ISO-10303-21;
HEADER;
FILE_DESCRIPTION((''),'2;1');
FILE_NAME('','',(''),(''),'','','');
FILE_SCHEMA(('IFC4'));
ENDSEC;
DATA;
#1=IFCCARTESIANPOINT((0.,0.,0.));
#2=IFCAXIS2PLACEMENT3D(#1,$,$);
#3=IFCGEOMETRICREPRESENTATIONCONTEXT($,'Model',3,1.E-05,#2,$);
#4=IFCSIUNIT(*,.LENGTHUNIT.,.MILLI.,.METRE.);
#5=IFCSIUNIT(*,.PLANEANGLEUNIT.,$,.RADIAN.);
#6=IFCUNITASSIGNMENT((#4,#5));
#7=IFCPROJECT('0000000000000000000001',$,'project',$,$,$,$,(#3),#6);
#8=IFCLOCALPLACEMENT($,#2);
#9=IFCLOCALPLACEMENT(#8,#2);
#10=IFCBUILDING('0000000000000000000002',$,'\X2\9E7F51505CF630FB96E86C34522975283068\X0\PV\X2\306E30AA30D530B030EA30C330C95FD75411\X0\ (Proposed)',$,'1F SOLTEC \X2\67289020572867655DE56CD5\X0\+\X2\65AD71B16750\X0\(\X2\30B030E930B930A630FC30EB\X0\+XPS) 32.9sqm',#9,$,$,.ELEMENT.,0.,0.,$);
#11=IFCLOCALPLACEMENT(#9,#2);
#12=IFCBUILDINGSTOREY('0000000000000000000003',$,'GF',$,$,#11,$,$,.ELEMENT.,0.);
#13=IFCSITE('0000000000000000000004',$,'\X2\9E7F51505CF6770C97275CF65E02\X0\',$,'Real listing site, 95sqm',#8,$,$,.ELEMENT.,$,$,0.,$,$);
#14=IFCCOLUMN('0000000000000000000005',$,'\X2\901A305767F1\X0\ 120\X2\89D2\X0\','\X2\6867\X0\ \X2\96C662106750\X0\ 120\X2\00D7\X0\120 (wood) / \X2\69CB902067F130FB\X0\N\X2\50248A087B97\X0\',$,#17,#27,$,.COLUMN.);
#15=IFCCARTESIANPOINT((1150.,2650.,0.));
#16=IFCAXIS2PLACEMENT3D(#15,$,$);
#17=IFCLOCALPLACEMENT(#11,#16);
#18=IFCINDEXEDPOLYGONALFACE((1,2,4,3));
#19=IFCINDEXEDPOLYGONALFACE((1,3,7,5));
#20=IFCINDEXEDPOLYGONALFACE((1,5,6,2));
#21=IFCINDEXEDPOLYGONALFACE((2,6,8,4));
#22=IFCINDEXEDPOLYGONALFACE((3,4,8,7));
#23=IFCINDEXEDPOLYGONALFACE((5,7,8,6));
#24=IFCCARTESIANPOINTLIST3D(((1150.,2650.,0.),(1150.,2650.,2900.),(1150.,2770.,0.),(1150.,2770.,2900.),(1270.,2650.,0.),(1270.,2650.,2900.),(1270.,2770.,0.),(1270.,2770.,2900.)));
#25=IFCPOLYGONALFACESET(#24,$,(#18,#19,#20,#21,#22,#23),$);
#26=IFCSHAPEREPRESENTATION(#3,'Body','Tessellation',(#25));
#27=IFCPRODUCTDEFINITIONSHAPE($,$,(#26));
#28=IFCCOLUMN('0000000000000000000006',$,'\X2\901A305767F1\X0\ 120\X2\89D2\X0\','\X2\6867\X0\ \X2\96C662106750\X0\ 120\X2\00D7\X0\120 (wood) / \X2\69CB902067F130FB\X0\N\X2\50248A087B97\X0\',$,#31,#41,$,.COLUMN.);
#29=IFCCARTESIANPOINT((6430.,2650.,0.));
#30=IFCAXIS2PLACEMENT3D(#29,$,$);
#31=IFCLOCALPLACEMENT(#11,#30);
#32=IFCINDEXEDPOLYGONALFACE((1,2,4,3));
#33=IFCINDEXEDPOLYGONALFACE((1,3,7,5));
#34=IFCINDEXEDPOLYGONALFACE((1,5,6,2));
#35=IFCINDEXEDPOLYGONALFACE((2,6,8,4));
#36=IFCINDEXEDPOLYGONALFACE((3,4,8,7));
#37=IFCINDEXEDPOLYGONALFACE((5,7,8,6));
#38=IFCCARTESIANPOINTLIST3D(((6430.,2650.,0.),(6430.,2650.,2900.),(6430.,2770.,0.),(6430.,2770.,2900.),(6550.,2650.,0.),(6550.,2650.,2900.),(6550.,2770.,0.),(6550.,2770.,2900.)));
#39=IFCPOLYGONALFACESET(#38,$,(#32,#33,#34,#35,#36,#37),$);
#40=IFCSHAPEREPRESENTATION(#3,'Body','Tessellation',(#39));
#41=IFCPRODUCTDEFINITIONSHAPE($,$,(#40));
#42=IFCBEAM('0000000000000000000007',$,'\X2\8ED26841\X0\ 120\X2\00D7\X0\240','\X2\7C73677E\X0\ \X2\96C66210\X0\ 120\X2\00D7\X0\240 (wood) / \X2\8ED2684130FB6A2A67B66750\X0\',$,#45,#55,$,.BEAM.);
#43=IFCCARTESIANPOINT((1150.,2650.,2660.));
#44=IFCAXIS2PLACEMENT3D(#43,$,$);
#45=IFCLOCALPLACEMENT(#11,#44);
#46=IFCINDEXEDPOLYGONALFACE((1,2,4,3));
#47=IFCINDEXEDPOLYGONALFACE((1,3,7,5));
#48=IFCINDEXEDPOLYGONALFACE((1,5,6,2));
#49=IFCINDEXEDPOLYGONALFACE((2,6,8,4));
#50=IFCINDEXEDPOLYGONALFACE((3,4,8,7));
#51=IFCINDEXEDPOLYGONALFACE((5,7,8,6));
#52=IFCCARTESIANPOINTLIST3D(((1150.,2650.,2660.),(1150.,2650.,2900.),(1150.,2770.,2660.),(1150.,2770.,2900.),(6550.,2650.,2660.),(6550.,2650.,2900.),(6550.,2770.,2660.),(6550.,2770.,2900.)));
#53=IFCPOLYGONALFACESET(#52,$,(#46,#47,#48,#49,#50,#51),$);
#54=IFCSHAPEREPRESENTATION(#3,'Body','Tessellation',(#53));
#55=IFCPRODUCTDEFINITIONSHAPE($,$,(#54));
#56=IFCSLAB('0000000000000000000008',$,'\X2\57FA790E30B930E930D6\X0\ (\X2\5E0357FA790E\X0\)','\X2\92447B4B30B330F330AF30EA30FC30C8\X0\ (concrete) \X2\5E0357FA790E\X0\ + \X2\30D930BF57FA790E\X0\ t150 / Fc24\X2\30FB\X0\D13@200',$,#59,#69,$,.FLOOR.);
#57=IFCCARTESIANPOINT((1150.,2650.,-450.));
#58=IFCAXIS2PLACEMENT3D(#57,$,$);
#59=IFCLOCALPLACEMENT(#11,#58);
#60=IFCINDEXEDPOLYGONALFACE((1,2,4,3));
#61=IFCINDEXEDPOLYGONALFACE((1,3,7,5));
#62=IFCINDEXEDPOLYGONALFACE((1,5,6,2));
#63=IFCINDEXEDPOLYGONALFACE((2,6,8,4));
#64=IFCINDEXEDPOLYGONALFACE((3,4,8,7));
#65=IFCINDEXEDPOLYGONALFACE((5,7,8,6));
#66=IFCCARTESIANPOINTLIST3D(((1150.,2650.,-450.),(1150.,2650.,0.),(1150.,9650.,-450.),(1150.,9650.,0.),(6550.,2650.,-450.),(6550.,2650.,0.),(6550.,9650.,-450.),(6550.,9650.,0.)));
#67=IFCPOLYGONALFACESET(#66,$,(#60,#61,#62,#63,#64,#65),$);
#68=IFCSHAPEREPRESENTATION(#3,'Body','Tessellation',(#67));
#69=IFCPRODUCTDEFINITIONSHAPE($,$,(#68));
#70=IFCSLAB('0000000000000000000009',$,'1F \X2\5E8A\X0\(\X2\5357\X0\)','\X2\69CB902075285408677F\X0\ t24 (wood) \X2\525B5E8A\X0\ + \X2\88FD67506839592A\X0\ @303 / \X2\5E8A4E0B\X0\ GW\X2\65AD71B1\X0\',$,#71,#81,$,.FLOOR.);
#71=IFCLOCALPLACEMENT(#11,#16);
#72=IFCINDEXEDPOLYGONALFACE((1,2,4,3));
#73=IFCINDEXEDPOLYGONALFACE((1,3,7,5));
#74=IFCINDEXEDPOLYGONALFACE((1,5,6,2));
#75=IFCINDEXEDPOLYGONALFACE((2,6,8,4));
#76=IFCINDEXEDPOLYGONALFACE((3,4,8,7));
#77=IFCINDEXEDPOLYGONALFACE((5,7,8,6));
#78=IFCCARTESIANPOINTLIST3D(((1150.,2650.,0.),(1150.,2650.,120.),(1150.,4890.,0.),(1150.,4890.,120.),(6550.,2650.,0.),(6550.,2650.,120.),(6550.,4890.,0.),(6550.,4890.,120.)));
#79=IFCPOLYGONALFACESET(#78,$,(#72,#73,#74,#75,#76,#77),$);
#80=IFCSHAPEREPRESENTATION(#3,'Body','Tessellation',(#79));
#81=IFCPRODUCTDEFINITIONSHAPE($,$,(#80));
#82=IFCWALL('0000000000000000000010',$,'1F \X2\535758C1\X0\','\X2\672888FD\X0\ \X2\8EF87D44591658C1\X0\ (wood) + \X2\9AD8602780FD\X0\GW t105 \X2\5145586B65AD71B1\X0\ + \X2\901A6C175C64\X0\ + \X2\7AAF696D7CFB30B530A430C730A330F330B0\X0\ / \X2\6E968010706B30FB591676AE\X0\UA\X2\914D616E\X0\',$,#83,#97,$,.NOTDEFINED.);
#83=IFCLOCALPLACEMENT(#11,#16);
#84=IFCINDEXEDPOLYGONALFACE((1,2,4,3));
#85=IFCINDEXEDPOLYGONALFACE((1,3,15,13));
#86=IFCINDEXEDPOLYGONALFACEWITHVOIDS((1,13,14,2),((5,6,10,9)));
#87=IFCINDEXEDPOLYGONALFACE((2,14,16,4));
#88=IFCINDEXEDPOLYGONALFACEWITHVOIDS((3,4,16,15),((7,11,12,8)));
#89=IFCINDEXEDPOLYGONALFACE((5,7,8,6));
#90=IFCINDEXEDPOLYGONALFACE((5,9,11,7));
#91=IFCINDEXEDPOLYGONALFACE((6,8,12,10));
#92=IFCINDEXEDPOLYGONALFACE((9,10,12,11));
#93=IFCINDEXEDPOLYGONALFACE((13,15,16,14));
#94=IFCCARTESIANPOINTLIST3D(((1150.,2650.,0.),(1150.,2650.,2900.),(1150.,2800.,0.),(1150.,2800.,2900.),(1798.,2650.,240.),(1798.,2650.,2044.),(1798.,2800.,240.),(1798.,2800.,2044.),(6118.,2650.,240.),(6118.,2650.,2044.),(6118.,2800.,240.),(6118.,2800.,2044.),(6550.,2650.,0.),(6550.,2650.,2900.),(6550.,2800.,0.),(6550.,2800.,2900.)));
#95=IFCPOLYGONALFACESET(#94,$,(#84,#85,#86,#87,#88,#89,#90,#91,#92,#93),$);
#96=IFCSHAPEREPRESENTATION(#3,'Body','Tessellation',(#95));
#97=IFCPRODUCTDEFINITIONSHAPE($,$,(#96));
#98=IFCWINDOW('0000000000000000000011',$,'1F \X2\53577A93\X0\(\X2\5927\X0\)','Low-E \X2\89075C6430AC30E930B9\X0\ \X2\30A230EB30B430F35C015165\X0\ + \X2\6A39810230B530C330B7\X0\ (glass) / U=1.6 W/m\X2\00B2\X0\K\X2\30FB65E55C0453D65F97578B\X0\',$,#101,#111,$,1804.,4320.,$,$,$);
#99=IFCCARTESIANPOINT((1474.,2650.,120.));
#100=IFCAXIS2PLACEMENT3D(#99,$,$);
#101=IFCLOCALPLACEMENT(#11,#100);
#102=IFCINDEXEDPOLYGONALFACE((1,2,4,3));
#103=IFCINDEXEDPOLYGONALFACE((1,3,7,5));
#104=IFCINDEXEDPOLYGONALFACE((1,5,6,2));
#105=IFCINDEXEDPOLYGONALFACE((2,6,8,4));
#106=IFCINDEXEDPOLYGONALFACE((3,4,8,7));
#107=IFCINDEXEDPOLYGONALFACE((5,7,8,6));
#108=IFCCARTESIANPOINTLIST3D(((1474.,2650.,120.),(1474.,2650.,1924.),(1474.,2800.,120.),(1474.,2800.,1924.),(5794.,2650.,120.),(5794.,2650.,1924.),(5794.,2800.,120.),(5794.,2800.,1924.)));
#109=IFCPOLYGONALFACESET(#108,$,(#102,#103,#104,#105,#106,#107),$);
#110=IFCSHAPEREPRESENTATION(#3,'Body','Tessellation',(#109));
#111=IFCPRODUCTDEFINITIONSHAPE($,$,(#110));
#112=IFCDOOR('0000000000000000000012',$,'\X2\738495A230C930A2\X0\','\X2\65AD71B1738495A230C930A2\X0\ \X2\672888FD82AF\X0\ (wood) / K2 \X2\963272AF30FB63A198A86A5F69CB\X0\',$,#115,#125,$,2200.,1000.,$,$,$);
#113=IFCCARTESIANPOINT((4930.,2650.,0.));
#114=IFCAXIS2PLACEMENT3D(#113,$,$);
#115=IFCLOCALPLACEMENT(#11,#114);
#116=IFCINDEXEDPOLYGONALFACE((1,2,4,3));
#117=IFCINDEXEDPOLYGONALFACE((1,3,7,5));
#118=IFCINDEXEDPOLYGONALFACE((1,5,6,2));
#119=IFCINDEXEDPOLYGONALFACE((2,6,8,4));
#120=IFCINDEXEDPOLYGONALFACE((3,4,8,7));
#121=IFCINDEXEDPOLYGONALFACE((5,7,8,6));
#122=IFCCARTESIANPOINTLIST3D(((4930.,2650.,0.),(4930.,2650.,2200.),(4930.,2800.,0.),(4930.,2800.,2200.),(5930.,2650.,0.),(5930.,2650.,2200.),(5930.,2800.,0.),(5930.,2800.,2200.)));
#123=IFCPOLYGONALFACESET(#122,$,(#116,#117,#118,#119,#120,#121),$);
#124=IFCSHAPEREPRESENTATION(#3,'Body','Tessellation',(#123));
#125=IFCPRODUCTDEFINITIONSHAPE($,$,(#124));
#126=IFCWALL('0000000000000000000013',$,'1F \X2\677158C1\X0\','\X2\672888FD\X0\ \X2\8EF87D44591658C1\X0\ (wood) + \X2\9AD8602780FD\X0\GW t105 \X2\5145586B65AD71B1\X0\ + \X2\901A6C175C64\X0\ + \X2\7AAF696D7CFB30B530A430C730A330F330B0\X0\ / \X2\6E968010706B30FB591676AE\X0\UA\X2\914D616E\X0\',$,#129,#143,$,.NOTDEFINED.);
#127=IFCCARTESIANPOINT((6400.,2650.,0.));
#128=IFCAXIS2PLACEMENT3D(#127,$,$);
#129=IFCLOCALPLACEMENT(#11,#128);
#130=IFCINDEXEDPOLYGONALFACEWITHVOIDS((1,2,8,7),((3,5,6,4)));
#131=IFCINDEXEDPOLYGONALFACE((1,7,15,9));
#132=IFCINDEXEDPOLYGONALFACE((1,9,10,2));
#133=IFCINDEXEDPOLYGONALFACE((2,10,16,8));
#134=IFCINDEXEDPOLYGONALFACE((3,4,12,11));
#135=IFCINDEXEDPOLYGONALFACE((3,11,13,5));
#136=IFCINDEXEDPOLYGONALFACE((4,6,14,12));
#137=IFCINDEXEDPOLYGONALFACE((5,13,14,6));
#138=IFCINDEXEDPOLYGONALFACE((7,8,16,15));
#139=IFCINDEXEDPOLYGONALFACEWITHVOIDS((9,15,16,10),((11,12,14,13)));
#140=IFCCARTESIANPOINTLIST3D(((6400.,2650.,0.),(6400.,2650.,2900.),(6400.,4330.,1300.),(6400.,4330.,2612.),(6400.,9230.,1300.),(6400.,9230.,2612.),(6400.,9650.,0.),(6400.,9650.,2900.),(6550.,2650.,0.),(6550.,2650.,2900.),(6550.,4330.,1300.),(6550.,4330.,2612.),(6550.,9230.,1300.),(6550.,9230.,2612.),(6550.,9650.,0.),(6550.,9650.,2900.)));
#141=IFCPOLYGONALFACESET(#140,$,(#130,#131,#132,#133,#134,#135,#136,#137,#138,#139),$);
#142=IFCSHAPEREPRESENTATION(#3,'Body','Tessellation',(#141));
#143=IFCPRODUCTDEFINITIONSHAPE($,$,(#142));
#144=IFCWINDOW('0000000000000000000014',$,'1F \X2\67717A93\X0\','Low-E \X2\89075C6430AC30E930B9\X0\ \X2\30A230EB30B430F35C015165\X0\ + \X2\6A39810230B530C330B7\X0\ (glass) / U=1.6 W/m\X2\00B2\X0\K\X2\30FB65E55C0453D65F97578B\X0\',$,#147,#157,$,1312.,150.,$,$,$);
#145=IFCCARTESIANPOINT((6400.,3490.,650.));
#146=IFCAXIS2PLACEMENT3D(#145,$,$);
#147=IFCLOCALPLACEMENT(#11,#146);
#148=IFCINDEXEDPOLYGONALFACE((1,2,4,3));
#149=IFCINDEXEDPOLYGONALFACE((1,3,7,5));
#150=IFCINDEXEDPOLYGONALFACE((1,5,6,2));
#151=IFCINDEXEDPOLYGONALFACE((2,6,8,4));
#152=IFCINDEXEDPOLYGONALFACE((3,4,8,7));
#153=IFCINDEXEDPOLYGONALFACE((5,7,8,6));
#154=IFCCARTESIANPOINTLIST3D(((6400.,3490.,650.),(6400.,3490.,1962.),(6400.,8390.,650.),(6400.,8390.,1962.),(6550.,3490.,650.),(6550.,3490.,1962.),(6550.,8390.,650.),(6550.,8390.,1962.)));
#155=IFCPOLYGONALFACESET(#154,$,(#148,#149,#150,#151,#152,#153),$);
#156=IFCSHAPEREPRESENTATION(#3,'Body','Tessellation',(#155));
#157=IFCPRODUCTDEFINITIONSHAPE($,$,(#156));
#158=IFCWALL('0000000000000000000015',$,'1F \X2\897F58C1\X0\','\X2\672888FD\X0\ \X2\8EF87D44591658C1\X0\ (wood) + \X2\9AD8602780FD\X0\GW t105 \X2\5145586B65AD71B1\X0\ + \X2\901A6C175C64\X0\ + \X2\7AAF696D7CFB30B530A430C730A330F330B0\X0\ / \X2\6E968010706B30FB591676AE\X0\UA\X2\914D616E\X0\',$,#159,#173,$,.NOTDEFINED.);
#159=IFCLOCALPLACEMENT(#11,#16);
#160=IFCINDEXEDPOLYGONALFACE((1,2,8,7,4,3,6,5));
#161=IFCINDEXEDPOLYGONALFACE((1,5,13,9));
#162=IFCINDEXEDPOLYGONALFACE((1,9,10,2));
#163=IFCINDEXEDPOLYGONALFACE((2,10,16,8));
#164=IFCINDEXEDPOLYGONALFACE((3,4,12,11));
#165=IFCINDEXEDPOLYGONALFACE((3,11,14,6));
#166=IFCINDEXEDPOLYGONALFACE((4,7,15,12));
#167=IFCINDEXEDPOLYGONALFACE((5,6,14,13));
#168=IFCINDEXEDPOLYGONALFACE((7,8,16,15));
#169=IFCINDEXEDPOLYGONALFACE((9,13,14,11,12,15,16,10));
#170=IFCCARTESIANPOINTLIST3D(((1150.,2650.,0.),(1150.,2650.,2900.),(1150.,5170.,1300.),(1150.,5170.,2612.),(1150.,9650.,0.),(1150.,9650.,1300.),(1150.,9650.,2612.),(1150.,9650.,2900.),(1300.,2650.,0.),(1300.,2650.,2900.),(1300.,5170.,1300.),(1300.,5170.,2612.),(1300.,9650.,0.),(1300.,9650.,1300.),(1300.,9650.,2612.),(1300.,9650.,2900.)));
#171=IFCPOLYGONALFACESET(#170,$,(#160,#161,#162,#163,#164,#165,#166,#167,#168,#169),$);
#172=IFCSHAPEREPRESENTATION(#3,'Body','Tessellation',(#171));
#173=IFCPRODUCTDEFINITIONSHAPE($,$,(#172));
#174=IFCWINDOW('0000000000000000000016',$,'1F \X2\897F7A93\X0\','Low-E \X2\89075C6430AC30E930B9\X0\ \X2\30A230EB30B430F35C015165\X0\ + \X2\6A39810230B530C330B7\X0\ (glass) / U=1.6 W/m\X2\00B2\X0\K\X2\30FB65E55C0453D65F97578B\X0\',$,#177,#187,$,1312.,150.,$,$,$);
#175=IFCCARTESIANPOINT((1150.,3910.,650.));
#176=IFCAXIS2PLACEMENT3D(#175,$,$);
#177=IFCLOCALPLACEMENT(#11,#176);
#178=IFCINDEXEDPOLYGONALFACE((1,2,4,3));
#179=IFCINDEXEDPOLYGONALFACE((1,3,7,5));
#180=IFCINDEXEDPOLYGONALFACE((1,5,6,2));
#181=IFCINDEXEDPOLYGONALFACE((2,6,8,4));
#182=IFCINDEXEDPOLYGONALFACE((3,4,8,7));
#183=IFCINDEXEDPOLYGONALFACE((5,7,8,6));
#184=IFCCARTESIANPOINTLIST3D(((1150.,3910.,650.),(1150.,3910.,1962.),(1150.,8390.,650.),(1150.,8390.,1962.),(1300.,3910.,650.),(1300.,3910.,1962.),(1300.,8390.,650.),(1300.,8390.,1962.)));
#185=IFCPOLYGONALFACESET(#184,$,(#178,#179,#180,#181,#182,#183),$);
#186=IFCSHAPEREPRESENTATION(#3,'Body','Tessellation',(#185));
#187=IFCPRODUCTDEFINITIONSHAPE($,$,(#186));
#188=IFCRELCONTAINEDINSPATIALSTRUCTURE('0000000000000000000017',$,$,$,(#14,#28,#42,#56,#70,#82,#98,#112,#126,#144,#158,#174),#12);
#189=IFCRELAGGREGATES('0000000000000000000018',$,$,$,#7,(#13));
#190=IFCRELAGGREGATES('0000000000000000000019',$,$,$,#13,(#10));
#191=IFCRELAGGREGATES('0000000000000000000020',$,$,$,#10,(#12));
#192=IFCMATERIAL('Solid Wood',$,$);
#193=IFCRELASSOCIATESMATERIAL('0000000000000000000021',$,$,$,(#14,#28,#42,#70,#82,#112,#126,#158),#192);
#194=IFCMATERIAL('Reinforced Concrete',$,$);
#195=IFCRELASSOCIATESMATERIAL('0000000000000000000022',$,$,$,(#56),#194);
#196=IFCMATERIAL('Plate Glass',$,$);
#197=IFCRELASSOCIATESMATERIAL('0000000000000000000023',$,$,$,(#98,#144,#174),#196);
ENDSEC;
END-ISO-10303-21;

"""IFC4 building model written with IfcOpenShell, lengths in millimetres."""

from ifc_helpers import new_model, si_unit, frame, frame_2d, origin, place, context, project, spatial, rectangle, extrude, material, element, fill, save


model = new_model("IFC4")

# Units and contexts
model_context = context("Model", 3, precision=1e-05, world=origin())
ifc_project = project(units=[si_unit("LENGTHUNIT", "METRE", prefix="MILLI"), si_unit("PLANEANGLEUNIT", "RADIAN")], contexts=[model_context])

# Site, building, storey
site_placement = place(None, origin())
site = spatial("IfcSite", under=ifc_project, at=site_placement, Name="鹿児島県霧島市", ObjectType="Real listing site, 95sqm", CompositionType="ELEMENT", RefElevation=0.0)
building_placement = place(site_placement, origin())
building = spatial("IfcBuilding", under=site, at=building_placement, Name="鹿児島・雨水利用とPVのオフグリッド志向 (Proposed)", ObjectType="1F SOLTEC 木造在来工法+断熱材(グラスウール+XPS) 32.9sqm", CompositionType="ELEMENT", ElevationOfRefHeight=0.0, ElevationOfTerrain=0.0)
storey_placement = place(building_placement, origin())
storey = spatial("IfcBuildingStorey", under=building, at=storey_placement, Name="GF", CompositionType="ELEMENT", Elevation=0.0)

# Columns
ifc_material_1 = material(Name="Solid Wood")
column_1_placement = place(storey_placement, frame((1150.0, 2650.0, 0.0)))
element("IfcColumn", 1, at=column_1_placement, inside=storey, material=ifc_material_1, Name="通し柱 120角", Description="桧 集成材 120×120 (wood) / 構造柱・N値計算", PredefinedType="COLUMN", context=model_context, shape_type="SweptSolid", body=[
    extrude(rectangle(XDim=120.0, YDim=120.0, at=frame_2d((60.0, 60.0))), frame((1150.0, 2650.0, 0.0)), (0.0, 0.0, 1.0), 2900.0),
])
column_2_placement = place(storey_placement, frame((6430.0, 2650.0, 0.0)))
element("IfcColumn", 2, at=column_2_placement, inside=storey, material=ifc_material_1, Name="通し柱 120角", Description="桧 集成材 120×120 (wood) / 構造柱・N値計算", PredefinedType="COLUMN", context=model_context, shape_type="SweptSolid", body=[
    extrude(rectangle(XDim=120.0, YDim=120.0, at=frame_2d((60.0, 60.0))), frame((6430.0, 2650.0, 0.0)), (0.0, 0.0, 1.0), 2900.0),
])

# Beam
beam_1_placement = place(storey_placement, frame((1150.0, 2650.0, 2660.0)))
element("IfcBeam", 3, at=beam_1_placement, inside=storey, material=ifc_material_1, Name="軒桁 120×240", Description="米松 集成 120×240 (wood) / 軒桁・横架材", PredefinedType="BEAM", context=model_context, shape_type="SweptSolid", body=[
    extrude(rectangle(XDim=5400.0, YDim=120.0, at=frame_2d((2700.0, 60.0))), frame((1150.0, 2650.0, 2660.0)), (0.0, 0.0, 1.0), 240.0),
])

# Slabs
ifc_material_2 = material(Name="Reinforced Concrete")
slab_1_placement = place(storey_placement, frame((1150.0, 2650.0, -450.0)))
element("IfcSlab", 4, at=slab_1_placement, inside=storey, material=ifc_material_2, Name="基礎スラブ (布基礎)", Description="鉄筋コンクリート (concrete) 布基礎 + ベタ基礎 t150 / Fc24・D13@200", PredefinedType="FLOOR", context=model_context, shape_type="SweptSolid", body=[
    extrude(rectangle(XDim=5400.0, YDim=7000.0, at=frame_2d((2700.0, 3500.0))), frame((1150.0, 2650.0, -450.0)), (0.0, 0.0, 1.0), 450.0),
])
slab_2_placement = place(storey_placement, frame((1150.0, 2650.0, 0.0)))
element("IfcSlab", 5, at=slab_2_placement, inside=storey, material=ifc_material_1, Name="1F 床(南)", Description="構造用合板 t24 (wood) 剛床 + 製材根太 @303 / 床下 GW断熱", PredefinedType="FLOOR", context=model_context, shape_type="SweptSolid", body=[
    extrude(rectangle(XDim=5400.0, YDim=2240.0, at=frame_2d((2700.0, 1120.0))), frame((1150.0, 2650.0, 0.0)), (0.0, 0.0, 1.0), 120.0),
])

# Wall, openings, window, door
wall_1_placement = place(storey_placement, frame((1150.0, 2650.0, 0.0)))
wall_1 = element("IfcWall", 6, at=wall_1_placement, inside=storey, material=ifc_material_1, Name="1F 南壁", Description="木製 軸組外壁 (wood) + 高性能GW t105 充填断熱 + 通気層 + 窯業系サイディング / 準耐火・外皮UA配慮", PredefinedType="NOTDEFINED", context=model_context, shape_type="SweptSolid", body=[
    extrude(rectangle(XDim=5400.0, YDim=150.0, at=frame_2d((2700.0, 75.0))), frame((1150.0, 2650.0, 0.0)), (0.0, 0.0, 1.0), 2900.0),
])
opening_1_placement = place(storey_placement, frame((1474.0, 2650.0, 120.0)))
opening_1 = element("IfcOpeningElement", 7, at=opening_1_placement, cuts=wall_1, PredefinedType="NOTDEFINED", context=model_context, shape_type="SweptSolid", body=[
    extrude(rectangle(XDim=4320.0, YDim=150.0, at=frame_2d((2160.0, 75.0))), frame((1474.0, 2650.0, 120.0)), (0.0, 0.0, 1.0), 1804.0),
])
opening_2_placement = place(storey_placement, frame((4930.0, 2650.0, 0.0)))
opening_2 = element("IfcOpeningElement", 8, at=opening_2_placement, cuts=wall_1, PredefinedType="NOTDEFINED", context=model_context, shape_type="SweptSolid", body=[
    extrude(rectangle(XDim=1000.0, YDim=150.0, at=frame_2d((500.0, 75.0))), frame((4930.0, 2650.0, 0.0)), (0.0, 0.0, 1.0), 2200.0),
])
ifc_material_3 = material(Name="Plate Glass")
window_1_placement = place(storey_placement, frame((1474.0, 2650.0, 120.0)))
window_1 = element("IfcWindow", 9, at=window_1_placement, inside=storey, material=ifc_material_3, Name="1F 南窓(大)", Description="Low-E 複層ガラス アルゴン封入 + 樹脂サッシ (glass) / U=1.6 W/m²K・日射取得型", OverallHeight=1804.0, OverallWidth=4320.0, context=model_context, shape_type="SweptSolid", body=[
    extrude(rectangle(XDim=4320.0, YDim=150.0, at=frame_2d((2160.0, 75.0))), frame((1474.0, 2650.0, 120.0)), (0.0, 0.0, 1.0), 1804.0),
])
fill(opening_1, window_1)
door_placement = place(storey_placement, frame((4930.0, 2650.0, 0.0)))
door = element("IfcDoor", 10, at=door_placement, inside=storey, material=ifc_material_1, Name="玄関ドア", Description="断熱玄関ドア 木製芯 (wood) / K2 防犯・採風機構", OverallHeight=2200.0, OverallWidth=1000.0, context=model_context, shape_type="SweptSolid", body=[
    extrude(rectangle(XDim=1000.0, YDim=150.0, at=frame_2d((500.0, 75.0))), frame((4930.0, 2650.0, 0.0)), (0.0, 0.0, 1.0), 2200.0),
])
fill(opening_2, door)

# Walls, openings, windows
wall_2_placement = place(storey_placement, frame((6400.0, 2650.0, 0.0)))
wall_2 = element("IfcWall", 11, at=wall_2_placement, inside=storey, material=ifc_material_1, Name="1F 東壁", Description="木製 軸組外壁 (wood) + 高性能GW t105 充填断熱 + 通気層 + 窯業系サイディング / 準耐火・外皮UA配慮", PredefinedType="NOTDEFINED", context=model_context, shape_type="SweptSolid", body=[
    extrude(rectangle(XDim=150.0, YDim=7000.0, at=frame_2d((75.0, 3500.0))), frame((6400.0, 2650.0, 0.0)), (0.0, 0.0, 1.0), 2900.0),
])
opening_3_placement = place(storey_placement, frame((6400.0, 3490.0, 650.0)))
opening_3 = element("IfcOpeningElement", 12, at=opening_3_placement, cuts=wall_2, PredefinedType="NOTDEFINED", context=model_context, shape_type="SweptSolid", body=[
    extrude(rectangle(XDim=150.0, YDim=4900.0, at=frame_2d((75.0, 2450.0))), frame((6400.0, 3490.0, 650.0)), (0.0, 0.0, 1.0), 1312.0),
])
window_2_placement = place(storey_placement, frame((6400.0, 3490.0, 650.0)))
window_2 = element("IfcWindow", 13, at=window_2_placement, inside=storey, material=ifc_material_3, Name="1F 東窓", Description="Low-E 複層ガラス アルゴン封入 + 樹脂サッシ (glass) / U=1.6 W/m²K・日射取得型", OverallHeight=1312.0, OverallWidth=150.0, context=model_context, shape_type="SweptSolid", body=[
    extrude(rectangle(XDim=150.0, YDim=4900.0, at=frame_2d((75.0, 2450.0))), frame((6400.0, 3490.0, 650.0)), (0.0, 0.0, 1.0), 1312.0),
])
fill(opening_3, window_2)
wall_3_placement = place(storey_placement, frame((1150.0, 2650.0, 0.0)))
wall_3 = element("IfcWall", 14, at=wall_3_placement, inside=storey, material=ifc_material_1, Name="1F 西壁", Description="木製 軸組外壁 (wood) + 高性能GW t105 充填断熱 + 通気層 + 窯業系サイディング / 準耐火・外皮UA配慮", PredefinedType="NOTDEFINED", context=model_context, shape_type="SweptSolid", body=[
    extrude(rectangle(XDim=150.0, YDim=7000.0, at=frame_2d((75.0, 3500.0))), frame((1150.0, 2650.0, 0.0)), (0.0, 0.0, 1.0), 2900.0),
])
opening_4_placement = place(storey_placement, frame((1150.0, 3910.0, 650.0)))
opening_4 = element("IfcOpeningElement", 15, at=opening_4_placement, cuts=wall_3, PredefinedType="NOTDEFINED", context=model_context, shape_type="SweptSolid", body=[
    extrude(rectangle(XDim=150.0, YDim=4480.0, at=frame_2d((75.0, 2240.0))), frame((1150.0, 3910.0, 650.0)), (0.0, 0.0, 1.0), 1312.0),
])
window_3_placement = place(storey_placement, frame((1150.0, 3910.0, 650.0)))
window_3 = element("IfcWindow", 16, at=window_3_placement, inside=storey, material=ifc_material_3, Name="1F 西窓", Description="Low-E 複層ガラス アルゴン封入 + 樹脂サッシ (glass) / U=1.6 W/m²K・日射取得型", OverallHeight=1312.0, OverallWidth=150.0, context=model_context, shape_type="SweptSolid", body=[
    extrude(rectangle(XDim=150.0, YDim=4480.0, at=frame_2d((75.0, 2240.0))), frame((1150.0, 3910.0, 650.0)), (0.0, 0.0, 1.0), 1312.0),
])
fill(opening_4, window_3)

save(model, "model.ifc")
